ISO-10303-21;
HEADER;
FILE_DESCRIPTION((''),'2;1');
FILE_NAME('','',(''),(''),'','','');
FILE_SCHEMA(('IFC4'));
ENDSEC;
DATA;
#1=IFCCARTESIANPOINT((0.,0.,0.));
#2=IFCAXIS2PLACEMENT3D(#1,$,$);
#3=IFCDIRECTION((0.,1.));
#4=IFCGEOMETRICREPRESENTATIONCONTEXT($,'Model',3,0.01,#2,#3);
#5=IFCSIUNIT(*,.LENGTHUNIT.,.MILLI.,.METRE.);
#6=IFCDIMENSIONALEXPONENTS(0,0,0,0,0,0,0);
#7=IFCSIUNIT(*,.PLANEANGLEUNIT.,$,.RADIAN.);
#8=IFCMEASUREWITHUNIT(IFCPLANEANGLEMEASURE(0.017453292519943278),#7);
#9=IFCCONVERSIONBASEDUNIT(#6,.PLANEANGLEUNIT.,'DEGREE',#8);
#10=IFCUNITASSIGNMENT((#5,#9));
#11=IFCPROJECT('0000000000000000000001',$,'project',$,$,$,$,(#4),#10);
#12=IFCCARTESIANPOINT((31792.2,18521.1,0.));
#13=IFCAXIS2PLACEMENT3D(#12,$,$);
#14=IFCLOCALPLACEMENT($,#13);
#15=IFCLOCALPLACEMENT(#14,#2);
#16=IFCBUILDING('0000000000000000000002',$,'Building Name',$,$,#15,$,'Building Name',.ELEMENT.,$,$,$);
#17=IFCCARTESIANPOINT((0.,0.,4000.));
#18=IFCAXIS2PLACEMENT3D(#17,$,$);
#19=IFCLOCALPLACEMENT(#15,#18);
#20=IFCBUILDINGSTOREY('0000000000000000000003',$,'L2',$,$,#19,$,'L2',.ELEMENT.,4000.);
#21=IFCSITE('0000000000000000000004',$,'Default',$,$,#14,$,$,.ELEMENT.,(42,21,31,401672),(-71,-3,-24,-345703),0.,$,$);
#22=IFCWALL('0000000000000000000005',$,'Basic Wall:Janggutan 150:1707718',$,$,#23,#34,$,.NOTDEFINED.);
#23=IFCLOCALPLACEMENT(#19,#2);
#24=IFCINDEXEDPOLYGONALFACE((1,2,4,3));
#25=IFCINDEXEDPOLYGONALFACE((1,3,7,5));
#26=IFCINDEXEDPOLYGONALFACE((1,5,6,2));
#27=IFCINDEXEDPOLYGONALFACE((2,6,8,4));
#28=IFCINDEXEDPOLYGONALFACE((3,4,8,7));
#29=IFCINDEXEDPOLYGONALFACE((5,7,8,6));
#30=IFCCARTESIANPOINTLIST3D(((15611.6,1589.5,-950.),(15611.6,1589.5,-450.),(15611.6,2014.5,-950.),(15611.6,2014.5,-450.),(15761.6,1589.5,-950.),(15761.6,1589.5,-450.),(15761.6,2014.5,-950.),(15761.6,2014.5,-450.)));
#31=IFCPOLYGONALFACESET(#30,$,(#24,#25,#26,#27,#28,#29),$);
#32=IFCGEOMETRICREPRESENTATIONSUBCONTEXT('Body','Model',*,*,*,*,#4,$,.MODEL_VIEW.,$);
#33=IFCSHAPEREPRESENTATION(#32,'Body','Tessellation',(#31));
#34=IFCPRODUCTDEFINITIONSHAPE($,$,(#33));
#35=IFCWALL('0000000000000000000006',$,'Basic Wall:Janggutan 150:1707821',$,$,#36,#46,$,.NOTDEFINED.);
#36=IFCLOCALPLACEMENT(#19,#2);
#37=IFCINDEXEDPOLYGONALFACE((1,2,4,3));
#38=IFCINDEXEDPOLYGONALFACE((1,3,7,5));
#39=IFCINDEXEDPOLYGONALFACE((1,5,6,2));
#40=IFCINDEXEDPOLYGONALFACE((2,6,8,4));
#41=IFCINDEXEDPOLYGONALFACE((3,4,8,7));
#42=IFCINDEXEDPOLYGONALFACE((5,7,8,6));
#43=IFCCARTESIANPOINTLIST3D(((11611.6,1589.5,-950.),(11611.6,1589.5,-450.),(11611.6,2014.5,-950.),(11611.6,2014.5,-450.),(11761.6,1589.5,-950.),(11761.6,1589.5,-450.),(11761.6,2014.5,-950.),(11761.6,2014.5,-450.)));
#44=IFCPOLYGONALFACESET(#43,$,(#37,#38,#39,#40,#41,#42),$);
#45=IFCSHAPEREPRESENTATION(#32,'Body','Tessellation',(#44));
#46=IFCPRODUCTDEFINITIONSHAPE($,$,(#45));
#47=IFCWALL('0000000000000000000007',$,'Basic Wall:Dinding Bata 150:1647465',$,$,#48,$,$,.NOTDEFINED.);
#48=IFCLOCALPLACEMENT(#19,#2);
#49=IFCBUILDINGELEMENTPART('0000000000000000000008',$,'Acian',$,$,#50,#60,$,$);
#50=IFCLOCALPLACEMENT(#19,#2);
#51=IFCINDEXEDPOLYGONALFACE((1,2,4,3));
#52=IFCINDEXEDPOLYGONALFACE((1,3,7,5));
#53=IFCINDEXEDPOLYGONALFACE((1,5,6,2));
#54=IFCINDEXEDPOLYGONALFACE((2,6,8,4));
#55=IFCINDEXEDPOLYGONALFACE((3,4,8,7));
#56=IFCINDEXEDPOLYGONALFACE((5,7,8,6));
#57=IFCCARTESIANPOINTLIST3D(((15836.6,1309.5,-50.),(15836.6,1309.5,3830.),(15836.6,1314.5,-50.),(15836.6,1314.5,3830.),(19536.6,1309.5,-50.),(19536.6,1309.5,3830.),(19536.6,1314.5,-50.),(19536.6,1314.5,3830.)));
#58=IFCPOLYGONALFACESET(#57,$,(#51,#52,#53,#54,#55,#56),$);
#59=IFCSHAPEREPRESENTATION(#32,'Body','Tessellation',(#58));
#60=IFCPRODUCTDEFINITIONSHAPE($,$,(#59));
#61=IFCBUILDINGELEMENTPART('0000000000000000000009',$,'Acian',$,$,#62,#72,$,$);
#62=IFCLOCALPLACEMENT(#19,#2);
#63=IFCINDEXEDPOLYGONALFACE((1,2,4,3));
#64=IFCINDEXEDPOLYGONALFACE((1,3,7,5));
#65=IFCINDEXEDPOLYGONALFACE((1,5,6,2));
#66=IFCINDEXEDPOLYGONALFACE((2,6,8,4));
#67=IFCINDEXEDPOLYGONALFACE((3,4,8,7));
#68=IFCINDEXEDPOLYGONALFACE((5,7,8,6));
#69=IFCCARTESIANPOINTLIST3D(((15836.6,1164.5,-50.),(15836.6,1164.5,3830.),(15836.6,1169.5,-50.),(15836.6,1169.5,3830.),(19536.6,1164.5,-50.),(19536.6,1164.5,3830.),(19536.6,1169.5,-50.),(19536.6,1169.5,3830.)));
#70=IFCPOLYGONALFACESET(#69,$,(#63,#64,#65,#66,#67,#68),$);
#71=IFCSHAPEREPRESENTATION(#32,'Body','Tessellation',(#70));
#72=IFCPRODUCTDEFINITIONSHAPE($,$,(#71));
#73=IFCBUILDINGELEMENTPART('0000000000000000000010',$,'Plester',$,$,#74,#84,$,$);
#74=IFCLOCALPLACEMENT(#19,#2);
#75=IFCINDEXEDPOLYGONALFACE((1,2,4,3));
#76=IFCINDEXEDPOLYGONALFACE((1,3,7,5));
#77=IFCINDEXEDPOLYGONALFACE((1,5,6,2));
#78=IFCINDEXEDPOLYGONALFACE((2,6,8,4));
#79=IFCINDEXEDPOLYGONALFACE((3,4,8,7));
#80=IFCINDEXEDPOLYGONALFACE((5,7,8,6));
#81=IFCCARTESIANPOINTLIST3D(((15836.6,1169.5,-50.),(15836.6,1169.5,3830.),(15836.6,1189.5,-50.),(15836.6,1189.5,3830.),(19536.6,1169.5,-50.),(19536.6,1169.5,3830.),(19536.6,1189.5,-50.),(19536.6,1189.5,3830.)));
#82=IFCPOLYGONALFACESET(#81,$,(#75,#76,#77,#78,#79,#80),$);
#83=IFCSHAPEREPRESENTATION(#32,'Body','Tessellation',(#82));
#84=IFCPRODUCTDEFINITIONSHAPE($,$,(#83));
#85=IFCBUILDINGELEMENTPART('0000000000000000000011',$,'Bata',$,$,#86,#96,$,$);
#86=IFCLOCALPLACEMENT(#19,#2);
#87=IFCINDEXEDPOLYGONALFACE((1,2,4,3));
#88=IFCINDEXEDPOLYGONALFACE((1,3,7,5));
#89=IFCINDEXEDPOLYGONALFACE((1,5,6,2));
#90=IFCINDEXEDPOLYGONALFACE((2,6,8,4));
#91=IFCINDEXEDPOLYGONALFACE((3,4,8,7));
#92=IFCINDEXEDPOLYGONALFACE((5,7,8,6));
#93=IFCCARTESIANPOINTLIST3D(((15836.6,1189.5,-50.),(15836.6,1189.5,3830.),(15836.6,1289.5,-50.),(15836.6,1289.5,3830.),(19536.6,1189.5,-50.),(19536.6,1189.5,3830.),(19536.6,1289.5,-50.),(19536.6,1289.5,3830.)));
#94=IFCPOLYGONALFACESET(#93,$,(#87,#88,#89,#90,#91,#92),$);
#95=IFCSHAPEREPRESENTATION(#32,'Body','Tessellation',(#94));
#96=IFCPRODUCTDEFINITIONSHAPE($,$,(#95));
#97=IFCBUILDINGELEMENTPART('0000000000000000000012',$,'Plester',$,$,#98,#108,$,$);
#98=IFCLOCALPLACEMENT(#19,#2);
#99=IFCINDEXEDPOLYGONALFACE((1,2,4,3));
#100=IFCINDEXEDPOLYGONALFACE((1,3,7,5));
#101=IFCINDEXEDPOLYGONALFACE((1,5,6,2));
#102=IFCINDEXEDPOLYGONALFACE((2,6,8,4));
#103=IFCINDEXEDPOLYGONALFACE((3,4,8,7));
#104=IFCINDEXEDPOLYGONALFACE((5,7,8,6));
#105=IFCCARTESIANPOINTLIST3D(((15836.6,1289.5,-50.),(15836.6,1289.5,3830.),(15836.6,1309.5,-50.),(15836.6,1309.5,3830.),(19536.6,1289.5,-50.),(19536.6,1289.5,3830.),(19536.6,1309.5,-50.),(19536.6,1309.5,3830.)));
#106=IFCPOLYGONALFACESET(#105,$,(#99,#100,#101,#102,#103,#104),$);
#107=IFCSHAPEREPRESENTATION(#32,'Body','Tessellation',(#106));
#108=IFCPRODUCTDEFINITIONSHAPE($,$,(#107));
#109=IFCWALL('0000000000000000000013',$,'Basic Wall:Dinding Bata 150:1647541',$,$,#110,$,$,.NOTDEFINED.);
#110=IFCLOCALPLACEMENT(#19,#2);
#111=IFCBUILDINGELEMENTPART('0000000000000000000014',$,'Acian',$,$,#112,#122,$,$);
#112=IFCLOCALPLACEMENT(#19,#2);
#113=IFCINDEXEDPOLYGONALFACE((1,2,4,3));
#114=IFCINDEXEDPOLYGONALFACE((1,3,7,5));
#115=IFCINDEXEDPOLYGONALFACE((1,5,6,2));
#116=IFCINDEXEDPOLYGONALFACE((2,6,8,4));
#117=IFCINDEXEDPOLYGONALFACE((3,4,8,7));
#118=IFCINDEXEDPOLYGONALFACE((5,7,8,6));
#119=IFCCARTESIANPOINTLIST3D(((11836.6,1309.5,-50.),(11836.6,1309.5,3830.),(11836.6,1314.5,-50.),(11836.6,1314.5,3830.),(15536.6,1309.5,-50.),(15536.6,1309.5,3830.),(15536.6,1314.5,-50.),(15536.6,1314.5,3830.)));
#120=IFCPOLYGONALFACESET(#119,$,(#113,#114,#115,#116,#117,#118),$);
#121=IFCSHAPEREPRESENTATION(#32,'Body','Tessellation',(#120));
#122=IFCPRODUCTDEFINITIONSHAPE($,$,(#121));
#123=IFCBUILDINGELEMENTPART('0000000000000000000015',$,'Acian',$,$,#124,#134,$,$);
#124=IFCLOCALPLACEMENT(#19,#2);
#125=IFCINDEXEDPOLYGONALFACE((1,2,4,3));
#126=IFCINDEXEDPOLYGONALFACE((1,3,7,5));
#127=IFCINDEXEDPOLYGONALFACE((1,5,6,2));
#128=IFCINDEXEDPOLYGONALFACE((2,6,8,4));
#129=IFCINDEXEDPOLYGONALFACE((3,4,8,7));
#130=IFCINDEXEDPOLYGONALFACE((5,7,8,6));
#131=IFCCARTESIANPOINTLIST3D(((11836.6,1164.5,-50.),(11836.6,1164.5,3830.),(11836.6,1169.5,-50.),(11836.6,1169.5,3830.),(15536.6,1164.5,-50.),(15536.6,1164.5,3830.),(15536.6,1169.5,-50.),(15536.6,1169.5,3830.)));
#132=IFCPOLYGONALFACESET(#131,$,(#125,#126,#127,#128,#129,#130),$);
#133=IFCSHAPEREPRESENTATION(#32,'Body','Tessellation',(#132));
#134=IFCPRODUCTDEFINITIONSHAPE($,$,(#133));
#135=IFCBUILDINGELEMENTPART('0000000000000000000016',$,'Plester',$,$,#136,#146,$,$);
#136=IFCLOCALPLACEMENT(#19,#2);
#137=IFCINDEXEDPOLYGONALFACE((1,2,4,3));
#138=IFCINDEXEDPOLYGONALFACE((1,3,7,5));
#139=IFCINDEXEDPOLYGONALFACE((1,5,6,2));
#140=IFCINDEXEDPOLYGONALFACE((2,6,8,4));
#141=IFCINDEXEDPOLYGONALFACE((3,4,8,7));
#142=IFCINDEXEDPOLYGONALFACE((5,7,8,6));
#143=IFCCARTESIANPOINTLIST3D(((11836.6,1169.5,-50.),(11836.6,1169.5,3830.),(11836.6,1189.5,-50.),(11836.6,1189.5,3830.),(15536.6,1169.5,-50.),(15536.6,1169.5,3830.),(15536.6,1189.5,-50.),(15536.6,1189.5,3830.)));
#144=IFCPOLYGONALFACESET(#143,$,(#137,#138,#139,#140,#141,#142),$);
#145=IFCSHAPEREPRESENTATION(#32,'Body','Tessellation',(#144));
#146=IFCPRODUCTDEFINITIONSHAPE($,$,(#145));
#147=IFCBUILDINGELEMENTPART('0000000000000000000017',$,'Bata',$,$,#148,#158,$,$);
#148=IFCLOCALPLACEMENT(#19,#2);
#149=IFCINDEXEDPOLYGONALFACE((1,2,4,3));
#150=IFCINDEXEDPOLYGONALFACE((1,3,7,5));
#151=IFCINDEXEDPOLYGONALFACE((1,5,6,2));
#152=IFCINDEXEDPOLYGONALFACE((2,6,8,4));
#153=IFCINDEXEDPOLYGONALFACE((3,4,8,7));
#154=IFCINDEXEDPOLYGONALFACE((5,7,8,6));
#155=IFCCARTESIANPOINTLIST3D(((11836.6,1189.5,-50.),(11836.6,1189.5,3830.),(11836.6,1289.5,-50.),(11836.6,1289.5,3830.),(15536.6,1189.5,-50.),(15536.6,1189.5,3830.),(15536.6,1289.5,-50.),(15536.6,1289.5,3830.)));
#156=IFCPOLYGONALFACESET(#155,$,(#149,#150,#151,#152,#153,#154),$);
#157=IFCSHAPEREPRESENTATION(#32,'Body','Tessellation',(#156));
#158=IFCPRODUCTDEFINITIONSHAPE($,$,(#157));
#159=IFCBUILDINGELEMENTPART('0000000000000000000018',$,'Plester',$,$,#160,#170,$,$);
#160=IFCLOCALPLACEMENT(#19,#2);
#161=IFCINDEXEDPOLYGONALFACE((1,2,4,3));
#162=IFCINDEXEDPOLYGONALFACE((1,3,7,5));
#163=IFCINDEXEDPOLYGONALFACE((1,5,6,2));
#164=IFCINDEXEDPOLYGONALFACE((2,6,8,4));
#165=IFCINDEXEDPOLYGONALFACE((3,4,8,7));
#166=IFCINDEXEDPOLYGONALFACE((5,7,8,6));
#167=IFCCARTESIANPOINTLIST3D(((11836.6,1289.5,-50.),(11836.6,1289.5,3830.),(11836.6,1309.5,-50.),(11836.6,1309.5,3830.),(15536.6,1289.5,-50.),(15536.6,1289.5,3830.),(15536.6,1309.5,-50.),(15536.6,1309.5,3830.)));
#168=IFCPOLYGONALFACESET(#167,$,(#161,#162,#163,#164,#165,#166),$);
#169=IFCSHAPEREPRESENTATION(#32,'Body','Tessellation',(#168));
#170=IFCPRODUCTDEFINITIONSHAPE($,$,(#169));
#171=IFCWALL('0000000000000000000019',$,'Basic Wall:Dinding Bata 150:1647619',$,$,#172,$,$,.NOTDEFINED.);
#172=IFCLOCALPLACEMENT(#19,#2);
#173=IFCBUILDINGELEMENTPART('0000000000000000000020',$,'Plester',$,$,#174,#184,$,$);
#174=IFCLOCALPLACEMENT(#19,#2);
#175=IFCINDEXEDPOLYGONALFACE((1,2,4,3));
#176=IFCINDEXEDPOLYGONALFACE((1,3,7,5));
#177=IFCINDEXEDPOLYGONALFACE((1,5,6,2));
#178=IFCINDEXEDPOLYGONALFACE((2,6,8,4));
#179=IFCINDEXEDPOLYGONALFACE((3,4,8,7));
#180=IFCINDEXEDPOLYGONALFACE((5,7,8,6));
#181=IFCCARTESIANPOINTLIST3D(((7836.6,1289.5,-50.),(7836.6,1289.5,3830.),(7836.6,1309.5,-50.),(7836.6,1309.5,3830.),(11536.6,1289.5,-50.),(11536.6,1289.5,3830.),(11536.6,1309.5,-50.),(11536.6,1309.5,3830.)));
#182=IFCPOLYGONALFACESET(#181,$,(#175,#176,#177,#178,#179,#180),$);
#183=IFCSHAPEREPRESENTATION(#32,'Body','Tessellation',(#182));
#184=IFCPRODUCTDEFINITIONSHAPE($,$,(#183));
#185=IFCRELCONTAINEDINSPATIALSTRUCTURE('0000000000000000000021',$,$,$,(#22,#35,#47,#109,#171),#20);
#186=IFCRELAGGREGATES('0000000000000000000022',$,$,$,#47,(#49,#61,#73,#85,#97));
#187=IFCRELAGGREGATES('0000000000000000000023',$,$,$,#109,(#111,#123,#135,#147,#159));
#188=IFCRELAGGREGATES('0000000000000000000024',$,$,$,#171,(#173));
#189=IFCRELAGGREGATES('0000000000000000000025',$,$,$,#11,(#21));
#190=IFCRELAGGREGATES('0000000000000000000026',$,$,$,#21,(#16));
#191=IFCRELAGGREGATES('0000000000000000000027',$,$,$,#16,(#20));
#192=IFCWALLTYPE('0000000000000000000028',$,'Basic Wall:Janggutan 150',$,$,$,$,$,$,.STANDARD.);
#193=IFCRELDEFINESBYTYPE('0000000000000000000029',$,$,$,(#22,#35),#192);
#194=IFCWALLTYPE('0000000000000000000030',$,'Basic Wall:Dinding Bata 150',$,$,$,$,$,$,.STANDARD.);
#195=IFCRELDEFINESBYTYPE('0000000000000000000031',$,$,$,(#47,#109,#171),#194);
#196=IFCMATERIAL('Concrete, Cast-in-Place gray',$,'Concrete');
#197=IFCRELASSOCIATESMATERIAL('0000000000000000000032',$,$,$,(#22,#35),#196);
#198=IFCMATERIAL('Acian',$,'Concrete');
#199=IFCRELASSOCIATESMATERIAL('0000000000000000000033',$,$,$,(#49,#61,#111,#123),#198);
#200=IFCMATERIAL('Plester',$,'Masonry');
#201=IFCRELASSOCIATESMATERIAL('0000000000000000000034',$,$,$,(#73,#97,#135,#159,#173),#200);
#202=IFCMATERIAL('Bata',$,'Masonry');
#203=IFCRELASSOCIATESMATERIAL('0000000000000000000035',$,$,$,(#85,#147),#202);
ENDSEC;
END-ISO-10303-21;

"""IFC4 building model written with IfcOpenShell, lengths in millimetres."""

from ifc_helpers import new_model, entity, si_unit, converted_unit, direction, frame, origin, place, context, subcontext, project, spatial, indexed_curve, outline, extrude, material, type_object, element, aggregate, save


model = new_model("IFC4")

# Units and contexts
model_context = context("Model", 3, precision=0.01, world=origin(), true_north=direction((0.0, 1.0)))
body_context = subcontext(model_context, "Body", "Model", "MODEL_VIEW")
ifc_project = project(units=[si_unit("LENGTHUNIT", "METRE", prefix="MILLI"), converted_unit("PLANEANGLEUNIT", "DEGREE", entity("IfcPlaneAngleMeasure", 0.017453292519943278), si_unit("PLANEANGLEUNIT", "RADIAN"), dimensions=[0, 0, 0, 0, 0, 0, 0])], contexts=[model_context])

# Site, building, storey
site_placement = place(None, frame((31792.2, 18521.1, 0.0)))
site = spatial("IfcSite", under=ifc_project, at=site_placement, Name="Default", CompositionType="ELEMENT", RefLatitude=(42, 21, 31, 401672), RefLongitude=(-71, -3, -24, -345703), RefElevation=0.0)
building_placement = place(site_placement, origin())
building = spatial("IfcBuilding", under=site, at=building_placement, Name="Building Name", LongName="Building Name", CompositionType="ELEMENT")
storey_placement = place(building_placement, frame((0.0, 0.0, 4000.0)))
storey = spatial("IfcBuildingStorey", under=building, at=storey_placement, Name="L2", LongName="L2", CompositionType="ELEMENT", Elevation=4000.0)

# Walls
ifc_material_1 = material(Name="Concrete, Cast-in-Place gray", Category="Concrete")
wall_type_1 = type_object("IfcWallType", Name="Basic Wall:Janggutan 150", PredefinedType="STANDARD")
wall_1_placement = place(storey_placement, frame((15686.6, 2014.5, -950.0), z_axis=(0.0, 0.0, 1.0), x_axis=(0.0, -1.0, 0.0)))
element("IfcWall", 1, at=wall_1_placement, inside=storey, type_object=wall_type_1, material=ifc_material_1, Name="Basic Wall:Janggutan 150:1707718", PredefinedType="NOTDEFINED", context=body_context, shape_type="SweptSolid", body=[
    extrude(outline(indexed_curve([(425.0, 75.0), (0.0, 75.0), (0.0, -75.0), (425.0, -75.0), (425.0, 75.0)], self_intersect=False)), origin(), (0.0, 0.0, 1.0), 500.0),
])
wall_2_placement = place(storey_placement, frame((11686.6, 2014.5, -950.0), z_axis=(0.0, 0.0, 1.0), x_axis=(0.0, -1.0, 0.0)))
element("IfcWall", 2, at=wall_2_placement, inside=storey, type_object=wall_type_1, material=ifc_material_1, Name="Basic Wall:Janggutan 150:1707821", PredefinedType="NOTDEFINED", context=body_context, shape_type="SweptSolid", body=[
    extrude(outline(indexed_curve([(425.0, 75.0), (0.0, 75.0), (0.0, -75.0), (425.0, -75.0), (425.0, 75.0)], self_intersect=False)), origin(), (0.0, 0.0, 1.0), 500.0),
])

# Walls, building element parts
wall_type_2 = type_object("IfcWallType", Name="Basic Wall:Dinding Bata 150", PredefinedType="STANDARD")
wall_3_placement = place(storey_placement, frame((19536.6, 1239.5, -50.0), z_axis=(0.0, 0.0, 1.0), x_axis=(-1.0, 0.0, 0.0)))
wall_3 = element("IfcWall", 3, at=wall_3_placement, inside=storey, type_object=wall_type_2, Name="Basic Wall:Dinding Bata 150:1647465", PredefinedType="NOTDEFINED")
ifc_material_2 = material(Name="Acian", Category="Concrete")
building_element_part_1_placement = place(wall_3_placement, origin())
building_element_part_1 = element("IfcBuildingElementPart", 4, at=building_element_part_1_placement, material=ifc_material_2, Name="Acian", context=body_context, shape_type="SweptSolid", body=[
    extrude(outline(indexed_curve([(-2.5, -1850.0), (2.5, -1850.0), (2.5, 1850.0), (-2.5, 1850.0), (-2.5, -1850.0)], self_intersect=False)), frame((1850.0, -72.5, 0.0), z_axis=(0.0, 0.0, 1.0), x_axis=(0.0, 1.0, 0.0)), (0.0, 0.0, 1.0), 3880.0),
])
building_element_part_2_placement = place(wall_3_placement, origin())
building_element_part_2 = element("IfcBuildingElementPart", 5, at=building_element_part_2_placement, material=ifc_material_2, Name="Acian", context=body_context, shape_type="SweptSolid", body=[
    extrude(outline(indexed_curve([(-2.5, -1850.0), (2.5, -1850.0), (2.5, 1850.0), (-2.5, 1850.0), (-2.5, -1850.0)], self_intersect=False)), frame((1850.0, 72.5, 0.0), z_axis=(0.0, 0.0, 1.0), x_axis=(0.0, 1.0, 0.0)), (0.0, 0.0, 1.0), 3880.0),
])
ifc_material_3 = material(Name="Plester", Category="Masonry")
building_element_part_3_placement = place(wall_3_placement, origin())
building_element_part_3 = element("IfcBuildingElementPart", 6, at=building_element_part_3_placement, material=ifc_material_3, Name="Plester", context=body_context, shape_type="SweptSolid", body=[
    extrude(outline(indexed_curve([(-10.0, -1850.0), (10.0, -1850.0), (10.0, 1850.0), (-10.0, 1850.0), (-10.0, -1850.0)], self_intersect=False)), frame((1850.0, 60.0, 0.0), z_axis=(0.0, 0.0, 1.0), x_axis=(0.0, 1.0, 0.0)), (0.0, 0.0, 1.0), 3880.0),
])
ifc_material_4 = material(Name="Bata", Category="Masonry")
building_element_part_4_placement = place(wall_3_placement, origin())
building_element_part_4 = element("IfcBuildingElementPart", 7, at=building_element_part_4_placement, material=ifc_material_4, Name="Bata", context=body_context, shape_type="SweptSolid", body=[
    extrude(outline(indexed_curve([(-50.0, -1850.0), (50.0, -1850.0), (50.0, 1850.0), (-50.0, 1850.0), (-50.0, -1850.0)], self_intersect=False)), frame((1850.0, 0.0, 0.0), z_axis=(0.0, 0.0, 1.0), x_axis=(0.0, 1.0, 0.0)), (0.0, 0.0, 1.0), 3880.0),
])
building_element_part_5_placement = place(wall_3_placement, origin())
building_element_part_5 = element("IfcBuildingElementPart", 8, at=building_element_part_5_placement, material=ifc_material_3, Name="Plester", context=body_context, shape_type="SweptSolid", body=[
    extrude(outline(indexed_curve([(-10.0, -1850.0), (10.0, -1850.0), (10.0, 1850.0), (-10.0, 1850.0), (-10.0, -1850.0)], self_intersect=False)), frame((1850.0, -60.0, 0.0), z_axis=(0.0, 0.0, 1.0), x_axis=(0.0, 1.0, 0.0)), (0.0, 0.0, 1.0), 3880.0),
])
aggregate(wall_3, [building_element_part_1, building_element_part_2, building_element_part_3, building_element_part_4, building_element_part_5])
wall_4_placement = place(storey_placement, frame((15536.6, 1239.5, -50.0), z_axis=(0.0, 0.0, 1.0), x_axis=(-1.0, 0.0, 0.0)))
wall_4 = element("IfcWall", 9, at=wall_4_placement, inside=storey, type_object=wall_type_2, Name="Basic Wall:Dinding Bata 150:1647541", PredefinedType="NOTDEFINED")
building_element_part_6_placement = place(wall_4_placement, origin())
building_element_part_6 = element("IfcBuildingElementPart", 10, at=building_element_part_6_placement, material=ifc_material_2, Name="Acian", context=body_context, shape_type="SweptSolid", body=[
    extrude(outline(indexed_curve([(-2.5, -1850.0), (2.5, -1850.0), (2.5, 1850.0), (-2.5, 1850.0), (-2.5, -1850.0)], self_intersect=False)), frame((1850.0, -72.5, 0.0), z_axis=(0.0, 0.0, 1.0), x_axis=(0.0, 1.0, 0.0)), (0.0, 0.0, 1.0), 3880.0),
])
building_element_part_7_placement = place(wall_4_placement, origin())
building_element_part_7 = element("IfcBuildingElementPart", 11, at=building_element_part_7_placement, material=ifc_material_2, Name="Acian", context=body_context, shape_type="SweptSolid", body=[
    extrude(outline(indexed_curve([(-2.5, -1850.0), (2.5, -1850.0), (2.5, 1850.0), (-2.5, 1850.0), (-2.5, -1850.0)], self_intersect=False)), frame((1850.0, 72.5, 0.0), z_axis=(0.0, 0.0, 1.0), x_axis=(0.0, 1.0, 0.0)), (0.0, 0.0, 1.0), 3880.0),
])
building_element_part_8_placement = place(wall_4_placement, origin())
building_element_part_8 = element("IfcBuildingElementPart", 12, at=building_element_part_8_placement, material=ifc_material_3, Name="Plester", context=body_context, shape_type="SweptSolid", body=[
    extrude(outline(indexed_curve([(-10.0, -1850.0), (10.0, -1850.0), (10.0, 1850.0), (-10.0, 1850.0), (-10.0, -1850.0)], self_intersect=False)), frame((1850.0, 60.0, 0.0), z_axis=(0.0, 0.0, 1.0), x_axis=(0.0, 1.0, 0.0)), (0.0, 0.0, 1.0), 3880.0),
])
building_element_part_9_placement = place(wall_4_placement, origin())
building_element_part_9 = element("IfcBuildingElementPart", 13, at=building_element_part_9_placement, material=ifc_material_4, Name="Bata", context=body_context, shape_type="SweptSolid", body=[
    extrude(outline(indexed_curve([(-50.0, -1850.0), (50.0, -1850.0), (50.0, 1850.0), (-50.0, 1850.0), (-50.0, -1850.0)], self_intersect=False)), frame((1850.0, 0.0, 0.0), z_axis=(0.0, 0.0, 1.0), x_axis=(0.0, 1.0, 0.0)), (0.0, 0.0, 1.0), 3880.0),
])
building_element_part_10_placement = place(wall_4_placement, origin())
building_element_part_10 = element("IfcBuildingElementPart", 14, at=building_element_part_10_placement, material=ifc_material_3, Name="Plester", context=body_context, shape_type="SweptSolid", body=[
    extrude(outline(indexed_curve([(-10.0, -1850.0), (10.0, -1850.0), (10.0, 1850.0), (-10.0, 1850.0), (-10.0, -1850.0)], self_intersect=False)), frame((1850.0, -60.0, 0.0), z_axis=(0.0, 0.0, 1.0), x_axis=(0.0, 1.0, 0.0)), (0.0, 0.0, 1.0), 3880.0),
])
aggregate(wall_4, [building_element_part_6, building_element_part_7, building_element_part_8, building_element_part_9, building_element_part_10])

# Wall, building element part
wall_5_placement = place(storey_placement, frame((11536.6, 1239.5, -50.0), z_axis=(0.0, 0.0, 1.0), x_axis=(-1.0, 0.0, 0.0)))
wall_5 = element("IfcWall", 15, at=wall_5_placement, inside=storey, type_object=wall_type_2, Name="Basic Wall:Dinding Bata 150:1647619", PredefinedType="NOTDEFINED")
building_element_part_11_placement = place(wall_5_placement, origin())
building_element_part_11 = element("IfcBuildingElementPart", 16, at=building_element_part_11_placement, material=ifc_material_3, Name="Plester", context=body_context, shape_type="SweptSolid", body=[
    extrude(outline(indexed_curve([(-10.0, -1850.0), (10.0, -1850.0), (10.0, 1850.0), (-10.0, 1850.0), (-10.0, -1850.0)], self_intersect=False)), frame((1850.0, -60.0, 0.0), z_axis=(0.0, 0.0, 1.0), x_axis=(0.0, 1.0, 0.0)), (0.0, 0.0, 1.0), 3880.0),
])
aggregate(wall_5, [building_element_part_11])

save(model, "model.ifc")
